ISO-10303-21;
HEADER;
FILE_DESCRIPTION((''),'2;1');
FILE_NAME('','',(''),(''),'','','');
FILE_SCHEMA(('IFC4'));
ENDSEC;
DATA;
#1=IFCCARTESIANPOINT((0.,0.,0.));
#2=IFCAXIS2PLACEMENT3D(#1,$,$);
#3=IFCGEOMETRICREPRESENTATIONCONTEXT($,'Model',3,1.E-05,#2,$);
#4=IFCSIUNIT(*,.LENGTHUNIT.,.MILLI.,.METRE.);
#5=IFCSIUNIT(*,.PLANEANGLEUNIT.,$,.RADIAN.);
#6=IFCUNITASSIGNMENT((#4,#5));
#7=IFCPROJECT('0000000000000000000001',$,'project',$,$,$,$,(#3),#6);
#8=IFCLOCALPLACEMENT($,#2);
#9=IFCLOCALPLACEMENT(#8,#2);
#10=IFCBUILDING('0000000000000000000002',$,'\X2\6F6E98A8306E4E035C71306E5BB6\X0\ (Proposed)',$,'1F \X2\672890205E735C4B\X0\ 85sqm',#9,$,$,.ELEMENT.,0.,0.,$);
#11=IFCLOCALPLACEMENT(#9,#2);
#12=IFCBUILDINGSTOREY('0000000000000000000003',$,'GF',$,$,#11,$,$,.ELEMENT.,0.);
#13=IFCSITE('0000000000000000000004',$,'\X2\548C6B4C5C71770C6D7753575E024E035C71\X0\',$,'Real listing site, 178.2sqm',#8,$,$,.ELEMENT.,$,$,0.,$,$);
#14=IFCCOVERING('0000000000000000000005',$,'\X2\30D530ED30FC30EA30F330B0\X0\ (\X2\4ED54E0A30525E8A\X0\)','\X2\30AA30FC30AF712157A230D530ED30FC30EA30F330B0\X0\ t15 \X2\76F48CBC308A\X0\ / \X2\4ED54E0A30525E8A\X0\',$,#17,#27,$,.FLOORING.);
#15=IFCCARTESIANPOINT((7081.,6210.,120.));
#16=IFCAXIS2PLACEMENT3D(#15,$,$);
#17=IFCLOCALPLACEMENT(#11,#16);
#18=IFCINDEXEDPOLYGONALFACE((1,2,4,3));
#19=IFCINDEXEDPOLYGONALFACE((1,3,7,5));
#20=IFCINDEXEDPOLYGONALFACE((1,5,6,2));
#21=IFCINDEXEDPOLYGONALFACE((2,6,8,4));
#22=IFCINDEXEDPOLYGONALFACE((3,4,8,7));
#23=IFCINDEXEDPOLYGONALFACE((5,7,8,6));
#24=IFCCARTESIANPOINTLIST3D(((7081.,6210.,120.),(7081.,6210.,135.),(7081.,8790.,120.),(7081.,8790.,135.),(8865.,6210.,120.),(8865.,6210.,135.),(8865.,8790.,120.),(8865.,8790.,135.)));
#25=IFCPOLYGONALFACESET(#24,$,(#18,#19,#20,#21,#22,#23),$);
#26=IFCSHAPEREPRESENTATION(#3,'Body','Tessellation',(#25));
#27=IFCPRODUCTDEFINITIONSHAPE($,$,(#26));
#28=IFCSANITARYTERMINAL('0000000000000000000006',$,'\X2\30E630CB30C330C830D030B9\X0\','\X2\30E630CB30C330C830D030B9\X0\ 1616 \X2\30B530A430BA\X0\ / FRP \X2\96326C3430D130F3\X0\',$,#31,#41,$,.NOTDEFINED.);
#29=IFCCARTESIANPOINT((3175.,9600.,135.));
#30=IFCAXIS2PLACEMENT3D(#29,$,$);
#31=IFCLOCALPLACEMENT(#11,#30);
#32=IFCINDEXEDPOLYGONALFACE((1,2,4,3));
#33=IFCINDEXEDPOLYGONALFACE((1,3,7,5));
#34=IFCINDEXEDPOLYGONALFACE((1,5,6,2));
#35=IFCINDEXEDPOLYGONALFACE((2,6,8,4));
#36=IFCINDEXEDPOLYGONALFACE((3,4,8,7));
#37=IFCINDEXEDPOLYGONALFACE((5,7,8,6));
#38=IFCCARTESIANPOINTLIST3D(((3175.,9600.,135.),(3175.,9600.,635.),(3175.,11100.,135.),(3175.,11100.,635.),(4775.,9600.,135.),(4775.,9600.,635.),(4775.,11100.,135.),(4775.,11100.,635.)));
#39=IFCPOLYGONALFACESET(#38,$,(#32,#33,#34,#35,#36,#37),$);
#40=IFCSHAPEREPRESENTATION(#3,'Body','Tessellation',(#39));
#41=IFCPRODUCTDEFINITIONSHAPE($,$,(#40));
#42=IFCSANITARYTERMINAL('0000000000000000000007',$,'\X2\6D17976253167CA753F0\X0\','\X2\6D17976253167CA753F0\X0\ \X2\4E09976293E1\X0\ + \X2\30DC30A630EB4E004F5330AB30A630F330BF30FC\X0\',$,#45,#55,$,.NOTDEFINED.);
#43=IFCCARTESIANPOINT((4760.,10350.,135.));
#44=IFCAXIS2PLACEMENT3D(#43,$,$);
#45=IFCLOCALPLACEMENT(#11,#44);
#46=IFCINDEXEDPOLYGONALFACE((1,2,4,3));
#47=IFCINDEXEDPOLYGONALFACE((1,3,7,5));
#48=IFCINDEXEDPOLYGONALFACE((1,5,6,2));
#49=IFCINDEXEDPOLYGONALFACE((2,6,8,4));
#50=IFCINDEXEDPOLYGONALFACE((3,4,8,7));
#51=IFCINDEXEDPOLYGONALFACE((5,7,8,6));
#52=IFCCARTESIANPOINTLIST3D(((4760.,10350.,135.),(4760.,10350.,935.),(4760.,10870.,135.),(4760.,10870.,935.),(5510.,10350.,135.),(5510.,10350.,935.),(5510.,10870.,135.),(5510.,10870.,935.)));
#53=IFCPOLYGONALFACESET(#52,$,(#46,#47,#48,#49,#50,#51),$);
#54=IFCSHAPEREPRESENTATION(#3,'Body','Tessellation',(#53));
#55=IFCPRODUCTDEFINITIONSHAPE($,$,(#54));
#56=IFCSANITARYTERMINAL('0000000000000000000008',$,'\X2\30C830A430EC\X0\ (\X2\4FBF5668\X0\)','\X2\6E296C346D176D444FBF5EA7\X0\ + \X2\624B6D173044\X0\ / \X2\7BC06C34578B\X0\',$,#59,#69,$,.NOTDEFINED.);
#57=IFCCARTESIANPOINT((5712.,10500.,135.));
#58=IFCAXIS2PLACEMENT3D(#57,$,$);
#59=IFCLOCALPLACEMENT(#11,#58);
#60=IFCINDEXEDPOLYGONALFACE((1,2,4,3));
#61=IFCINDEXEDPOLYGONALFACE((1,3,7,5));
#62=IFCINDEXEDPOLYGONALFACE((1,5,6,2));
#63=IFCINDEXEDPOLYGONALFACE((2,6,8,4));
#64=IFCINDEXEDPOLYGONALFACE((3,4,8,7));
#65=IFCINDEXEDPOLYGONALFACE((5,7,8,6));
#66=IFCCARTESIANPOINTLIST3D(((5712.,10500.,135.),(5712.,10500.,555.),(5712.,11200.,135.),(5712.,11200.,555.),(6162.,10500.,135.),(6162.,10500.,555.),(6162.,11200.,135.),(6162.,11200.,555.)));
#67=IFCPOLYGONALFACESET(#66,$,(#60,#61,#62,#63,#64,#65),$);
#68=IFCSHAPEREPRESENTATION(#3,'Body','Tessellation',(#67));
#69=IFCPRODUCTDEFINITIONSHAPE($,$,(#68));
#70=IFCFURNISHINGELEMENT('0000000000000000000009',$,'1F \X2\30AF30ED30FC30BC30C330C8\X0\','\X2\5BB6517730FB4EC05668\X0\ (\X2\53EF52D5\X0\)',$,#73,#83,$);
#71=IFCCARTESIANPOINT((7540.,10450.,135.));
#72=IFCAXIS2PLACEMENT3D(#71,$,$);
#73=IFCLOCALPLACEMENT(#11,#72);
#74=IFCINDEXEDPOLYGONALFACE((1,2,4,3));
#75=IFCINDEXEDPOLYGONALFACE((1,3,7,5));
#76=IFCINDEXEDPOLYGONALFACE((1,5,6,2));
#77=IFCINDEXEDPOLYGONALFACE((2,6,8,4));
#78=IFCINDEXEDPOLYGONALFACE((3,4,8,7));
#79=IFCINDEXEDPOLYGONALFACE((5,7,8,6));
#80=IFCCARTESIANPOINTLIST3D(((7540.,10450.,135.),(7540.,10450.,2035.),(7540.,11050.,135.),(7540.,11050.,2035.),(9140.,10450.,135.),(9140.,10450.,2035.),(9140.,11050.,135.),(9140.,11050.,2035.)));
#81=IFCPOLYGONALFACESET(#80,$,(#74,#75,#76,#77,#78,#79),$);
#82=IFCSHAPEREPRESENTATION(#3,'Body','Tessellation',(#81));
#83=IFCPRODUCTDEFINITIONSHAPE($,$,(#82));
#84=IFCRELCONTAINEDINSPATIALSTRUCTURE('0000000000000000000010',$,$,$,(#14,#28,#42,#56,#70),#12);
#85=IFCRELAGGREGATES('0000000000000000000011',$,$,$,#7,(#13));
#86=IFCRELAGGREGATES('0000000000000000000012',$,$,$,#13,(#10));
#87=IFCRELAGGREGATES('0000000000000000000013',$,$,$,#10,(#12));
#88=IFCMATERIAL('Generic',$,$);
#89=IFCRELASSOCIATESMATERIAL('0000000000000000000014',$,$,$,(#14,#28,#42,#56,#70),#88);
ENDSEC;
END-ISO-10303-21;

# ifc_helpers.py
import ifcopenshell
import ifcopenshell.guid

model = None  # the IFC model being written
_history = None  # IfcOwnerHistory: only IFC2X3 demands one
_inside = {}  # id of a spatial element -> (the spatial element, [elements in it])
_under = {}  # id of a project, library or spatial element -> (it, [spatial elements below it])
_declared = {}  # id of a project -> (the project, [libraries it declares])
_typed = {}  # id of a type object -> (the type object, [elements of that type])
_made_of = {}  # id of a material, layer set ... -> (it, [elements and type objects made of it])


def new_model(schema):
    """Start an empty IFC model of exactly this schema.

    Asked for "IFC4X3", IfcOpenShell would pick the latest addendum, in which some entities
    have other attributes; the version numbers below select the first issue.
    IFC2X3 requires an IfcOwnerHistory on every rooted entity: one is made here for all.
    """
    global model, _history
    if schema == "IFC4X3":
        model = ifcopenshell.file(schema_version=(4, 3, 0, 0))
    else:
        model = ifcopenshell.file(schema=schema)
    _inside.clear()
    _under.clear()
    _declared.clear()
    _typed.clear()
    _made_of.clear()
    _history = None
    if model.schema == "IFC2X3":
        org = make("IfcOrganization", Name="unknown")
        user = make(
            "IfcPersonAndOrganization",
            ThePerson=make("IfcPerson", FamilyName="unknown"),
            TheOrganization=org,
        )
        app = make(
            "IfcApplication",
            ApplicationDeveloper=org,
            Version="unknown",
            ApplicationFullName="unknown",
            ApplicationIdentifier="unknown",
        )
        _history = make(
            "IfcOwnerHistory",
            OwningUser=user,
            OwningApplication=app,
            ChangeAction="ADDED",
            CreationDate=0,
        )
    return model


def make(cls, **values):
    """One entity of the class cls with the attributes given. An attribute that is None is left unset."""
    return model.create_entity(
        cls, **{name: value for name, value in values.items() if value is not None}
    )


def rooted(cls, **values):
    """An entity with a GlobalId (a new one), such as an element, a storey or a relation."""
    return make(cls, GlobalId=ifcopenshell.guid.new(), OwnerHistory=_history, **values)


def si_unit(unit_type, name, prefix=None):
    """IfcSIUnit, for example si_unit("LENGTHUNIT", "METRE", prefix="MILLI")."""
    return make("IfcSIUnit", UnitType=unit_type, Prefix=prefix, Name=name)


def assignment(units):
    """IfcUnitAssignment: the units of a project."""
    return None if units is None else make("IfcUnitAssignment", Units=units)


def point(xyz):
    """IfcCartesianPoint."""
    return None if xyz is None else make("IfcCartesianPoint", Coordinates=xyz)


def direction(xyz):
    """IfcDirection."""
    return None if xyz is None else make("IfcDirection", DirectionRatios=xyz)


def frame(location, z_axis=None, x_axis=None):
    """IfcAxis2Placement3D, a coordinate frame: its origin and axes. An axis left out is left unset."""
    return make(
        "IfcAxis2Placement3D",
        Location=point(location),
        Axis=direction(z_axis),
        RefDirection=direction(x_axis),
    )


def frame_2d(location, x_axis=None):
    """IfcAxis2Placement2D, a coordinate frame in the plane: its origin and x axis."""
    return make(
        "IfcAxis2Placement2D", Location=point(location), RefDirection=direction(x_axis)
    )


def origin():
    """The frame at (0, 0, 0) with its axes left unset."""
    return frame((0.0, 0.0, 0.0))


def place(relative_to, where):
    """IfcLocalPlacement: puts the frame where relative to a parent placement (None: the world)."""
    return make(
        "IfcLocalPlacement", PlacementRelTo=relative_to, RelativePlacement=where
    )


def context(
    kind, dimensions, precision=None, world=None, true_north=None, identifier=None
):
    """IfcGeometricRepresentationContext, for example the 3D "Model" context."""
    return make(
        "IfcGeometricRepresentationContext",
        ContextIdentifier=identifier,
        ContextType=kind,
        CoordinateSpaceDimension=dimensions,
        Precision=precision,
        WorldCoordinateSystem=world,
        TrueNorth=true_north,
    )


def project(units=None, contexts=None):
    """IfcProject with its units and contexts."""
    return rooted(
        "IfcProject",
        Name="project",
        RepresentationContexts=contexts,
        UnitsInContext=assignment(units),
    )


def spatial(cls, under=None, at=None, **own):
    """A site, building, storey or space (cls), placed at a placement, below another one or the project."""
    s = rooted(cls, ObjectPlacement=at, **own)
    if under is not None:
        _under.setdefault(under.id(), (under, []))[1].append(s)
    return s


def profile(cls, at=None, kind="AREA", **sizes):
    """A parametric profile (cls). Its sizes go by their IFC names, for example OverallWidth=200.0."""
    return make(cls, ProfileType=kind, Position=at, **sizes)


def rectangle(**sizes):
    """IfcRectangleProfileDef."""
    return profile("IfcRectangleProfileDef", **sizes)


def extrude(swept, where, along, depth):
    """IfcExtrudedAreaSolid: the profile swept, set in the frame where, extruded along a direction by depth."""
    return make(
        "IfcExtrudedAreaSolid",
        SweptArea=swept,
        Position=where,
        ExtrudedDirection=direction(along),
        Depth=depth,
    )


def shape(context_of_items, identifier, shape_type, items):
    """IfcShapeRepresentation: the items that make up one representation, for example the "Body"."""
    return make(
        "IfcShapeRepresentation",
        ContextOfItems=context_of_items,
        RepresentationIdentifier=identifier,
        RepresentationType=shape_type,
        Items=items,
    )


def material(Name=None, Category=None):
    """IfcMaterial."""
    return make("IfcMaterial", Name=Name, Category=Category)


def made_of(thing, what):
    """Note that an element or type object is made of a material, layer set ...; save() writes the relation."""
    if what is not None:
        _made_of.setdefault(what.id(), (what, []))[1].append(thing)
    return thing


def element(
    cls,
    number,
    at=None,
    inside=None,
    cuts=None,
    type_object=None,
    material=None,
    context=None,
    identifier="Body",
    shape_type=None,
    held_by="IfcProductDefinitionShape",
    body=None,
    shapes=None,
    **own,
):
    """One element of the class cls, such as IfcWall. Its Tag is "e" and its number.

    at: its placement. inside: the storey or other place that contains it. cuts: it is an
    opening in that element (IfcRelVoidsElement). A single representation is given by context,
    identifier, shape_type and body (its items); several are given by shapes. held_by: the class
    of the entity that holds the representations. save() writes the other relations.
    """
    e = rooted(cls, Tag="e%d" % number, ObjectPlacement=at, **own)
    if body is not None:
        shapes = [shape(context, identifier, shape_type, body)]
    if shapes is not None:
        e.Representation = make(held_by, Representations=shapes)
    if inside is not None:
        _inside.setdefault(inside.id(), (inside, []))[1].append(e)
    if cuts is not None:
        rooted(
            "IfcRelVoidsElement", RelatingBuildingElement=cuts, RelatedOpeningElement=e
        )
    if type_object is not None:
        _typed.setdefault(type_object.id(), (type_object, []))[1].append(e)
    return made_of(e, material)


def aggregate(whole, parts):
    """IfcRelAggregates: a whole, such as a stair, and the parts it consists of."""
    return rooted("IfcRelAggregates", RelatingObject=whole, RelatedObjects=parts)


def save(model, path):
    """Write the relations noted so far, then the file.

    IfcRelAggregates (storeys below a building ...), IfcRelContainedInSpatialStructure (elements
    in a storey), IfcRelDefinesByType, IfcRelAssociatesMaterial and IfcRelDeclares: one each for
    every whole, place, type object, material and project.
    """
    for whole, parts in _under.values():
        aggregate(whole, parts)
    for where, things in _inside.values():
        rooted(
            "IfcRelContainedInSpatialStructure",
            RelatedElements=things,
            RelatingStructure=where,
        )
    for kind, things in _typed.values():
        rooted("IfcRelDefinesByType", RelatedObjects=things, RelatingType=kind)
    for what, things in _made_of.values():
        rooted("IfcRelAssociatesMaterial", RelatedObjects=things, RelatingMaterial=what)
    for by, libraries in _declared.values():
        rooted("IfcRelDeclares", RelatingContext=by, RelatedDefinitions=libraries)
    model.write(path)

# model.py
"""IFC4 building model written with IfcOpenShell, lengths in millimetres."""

from ifc_helpers import new_model, si_unit, frame, frame_2d, origin, place, context, project, spatial, rectangle, extrude, material, element, save


model = new_model("IFC4")

# Units and contexts
model_context = context("Model", 3, precision=1e-05, world=origin())
ifc_project = project(units=[si_unit("LENGTHUNIT", "METRE", prefix="MILLI"), si_unit("PLANEANGLEUNIT", "RADIAN")], contexts=[model_context])

# Site, building, storey
site_placement = place(None, origin())
site = spatial("IfcSite", under=ifc_project, at=site_placement, Name="和歌山県海南市七山", ObjectType="Real listing site, 178.2sqm", CompositionType="ELEMENT", RefElevation=0.0)
building_placement = place(site_placement, origin())
building = spatial("IfcBuilding", under=site, at=building_placement, Name="潮風の七山の家 (Proposed)", ObjectType="1F 木造平屋 85sqm", CompositionType="ELEMENT", ElevationOfRefHeight=0.0, ElevationOfTerrain=0.0)
storey_placement = place(building_placement, origin())
storey = spatial("IfcBuildingStorey", under=building, at=storey_placement, Name="GF", CompositionType="ELEMENT", Elevation=0.0)

# Covering
ifc_material_1 = material(Name="Generic")
covering_1_placement = place(storey_placement, frame((7081.0, 6210.0, 120.0)))
element("IfcCovering", 1, at=covering_1_placement, inside=storey, material=ifc_material_1, Name="フローリング (仕上げ床)", Description="オーク無垢フローリング t15 直貼り / 仕上げ床", PredefinedType="FLOORING", context=model_context, shape_type="SweptSolid", body=[
    extrude(rectangle(XDim=1784.0, YDim=2580.0, at=frame_2d((892.0, 1290.0))), frame((7081.0, 6210.0, 120.0)), (0.0, 0.0, 1.0), 15.0),
])

# Sanitary terminals
sanitary_terminal_1_placement = place(storey_placement, frame((3175.0, 9600.0, 135.0)))
element("IfcSanitaryTerminal", 2, at=sanitary_terminal_1_placement, inside=storey, material=ifc_material_1, Name="ユニットバス", Description="ユニットバス 1616 サイズ / FRP 防水パン", PredefinedType="NOTDEFINED", context=model_context, shape_type="SweptSolid", body=[
    extrude(rectangle(XDim=1600.0, YDim=1500.0, at=frame_2d((800.0, 750.0))), frame((3175.0, 9600.0, 135.0)), (0.0, 0.0, 1.0), 500.0),
])
sanitary_terminal_2_placement = place(storey_placement, frame((4760.0, 10350.0, 135.0)))
element("IfcSanitaryTerminal", 3, at=sanitary_terminal_2_placement, inside=storey, material=ifc_material_1, Name="洗面化粧台", Description="洗面化粧台 三面鏡 + ボウル一体カウンター", PredefinedType="NOTDEFINED", context=model_context, shape_type="SweptSolid", body=[
    extrude(rectangle(XDim=750.0, YDim=520.0, at=frame_2d((375.0, 260.0))), frame((4760.0, 10350.0, 135.0)), (0.0, 0.0, 1.0), 800.0),
])
sanitary_terminal_3_placement = place(storey_placement, frame((5712.0, 10500.0, 135.0)))
element("IfcSanitaryTerminal", 4, at=sanitary_terminal_3_placement, inside=storey, material=ifc_material_1, Name="トイレ (便器)", Description="温水洗浄便座 + 手洗い / 節水型", PredefinedType="NOTDEFINED", context=model_context, shape_type="SweptSolid", body=[
    extrude(rectangle(XDim=450.0, YDim=700.0, at=frame_2d((225.0, 350.0))), frame((5712.0, 10500.0, 135.0)), (0.0, 0.0, 1.0), 420.0),
])

# Furnishing element
furnishing_placement = place(storey_placement, frame((7540.0, 10450.0, 135.0)))
element("IfcFurnishingElement", 5, at=furnishing_placement, inside=storey, material=ifc_material_1, Name="1F クローゼット", Description="家具・什器 (可動)", context=model_context, shape_type="SweptSolid", body=[
    extrude(rectangle(XDim=1600.0, YDim=600.0, at=frame_2d((800.0, 300.0))), frame((7540.0, 10450.0, 135.0)), (0.0, 0.0, 1.0), 1900.0),
])

save(model, "model.ifc")
